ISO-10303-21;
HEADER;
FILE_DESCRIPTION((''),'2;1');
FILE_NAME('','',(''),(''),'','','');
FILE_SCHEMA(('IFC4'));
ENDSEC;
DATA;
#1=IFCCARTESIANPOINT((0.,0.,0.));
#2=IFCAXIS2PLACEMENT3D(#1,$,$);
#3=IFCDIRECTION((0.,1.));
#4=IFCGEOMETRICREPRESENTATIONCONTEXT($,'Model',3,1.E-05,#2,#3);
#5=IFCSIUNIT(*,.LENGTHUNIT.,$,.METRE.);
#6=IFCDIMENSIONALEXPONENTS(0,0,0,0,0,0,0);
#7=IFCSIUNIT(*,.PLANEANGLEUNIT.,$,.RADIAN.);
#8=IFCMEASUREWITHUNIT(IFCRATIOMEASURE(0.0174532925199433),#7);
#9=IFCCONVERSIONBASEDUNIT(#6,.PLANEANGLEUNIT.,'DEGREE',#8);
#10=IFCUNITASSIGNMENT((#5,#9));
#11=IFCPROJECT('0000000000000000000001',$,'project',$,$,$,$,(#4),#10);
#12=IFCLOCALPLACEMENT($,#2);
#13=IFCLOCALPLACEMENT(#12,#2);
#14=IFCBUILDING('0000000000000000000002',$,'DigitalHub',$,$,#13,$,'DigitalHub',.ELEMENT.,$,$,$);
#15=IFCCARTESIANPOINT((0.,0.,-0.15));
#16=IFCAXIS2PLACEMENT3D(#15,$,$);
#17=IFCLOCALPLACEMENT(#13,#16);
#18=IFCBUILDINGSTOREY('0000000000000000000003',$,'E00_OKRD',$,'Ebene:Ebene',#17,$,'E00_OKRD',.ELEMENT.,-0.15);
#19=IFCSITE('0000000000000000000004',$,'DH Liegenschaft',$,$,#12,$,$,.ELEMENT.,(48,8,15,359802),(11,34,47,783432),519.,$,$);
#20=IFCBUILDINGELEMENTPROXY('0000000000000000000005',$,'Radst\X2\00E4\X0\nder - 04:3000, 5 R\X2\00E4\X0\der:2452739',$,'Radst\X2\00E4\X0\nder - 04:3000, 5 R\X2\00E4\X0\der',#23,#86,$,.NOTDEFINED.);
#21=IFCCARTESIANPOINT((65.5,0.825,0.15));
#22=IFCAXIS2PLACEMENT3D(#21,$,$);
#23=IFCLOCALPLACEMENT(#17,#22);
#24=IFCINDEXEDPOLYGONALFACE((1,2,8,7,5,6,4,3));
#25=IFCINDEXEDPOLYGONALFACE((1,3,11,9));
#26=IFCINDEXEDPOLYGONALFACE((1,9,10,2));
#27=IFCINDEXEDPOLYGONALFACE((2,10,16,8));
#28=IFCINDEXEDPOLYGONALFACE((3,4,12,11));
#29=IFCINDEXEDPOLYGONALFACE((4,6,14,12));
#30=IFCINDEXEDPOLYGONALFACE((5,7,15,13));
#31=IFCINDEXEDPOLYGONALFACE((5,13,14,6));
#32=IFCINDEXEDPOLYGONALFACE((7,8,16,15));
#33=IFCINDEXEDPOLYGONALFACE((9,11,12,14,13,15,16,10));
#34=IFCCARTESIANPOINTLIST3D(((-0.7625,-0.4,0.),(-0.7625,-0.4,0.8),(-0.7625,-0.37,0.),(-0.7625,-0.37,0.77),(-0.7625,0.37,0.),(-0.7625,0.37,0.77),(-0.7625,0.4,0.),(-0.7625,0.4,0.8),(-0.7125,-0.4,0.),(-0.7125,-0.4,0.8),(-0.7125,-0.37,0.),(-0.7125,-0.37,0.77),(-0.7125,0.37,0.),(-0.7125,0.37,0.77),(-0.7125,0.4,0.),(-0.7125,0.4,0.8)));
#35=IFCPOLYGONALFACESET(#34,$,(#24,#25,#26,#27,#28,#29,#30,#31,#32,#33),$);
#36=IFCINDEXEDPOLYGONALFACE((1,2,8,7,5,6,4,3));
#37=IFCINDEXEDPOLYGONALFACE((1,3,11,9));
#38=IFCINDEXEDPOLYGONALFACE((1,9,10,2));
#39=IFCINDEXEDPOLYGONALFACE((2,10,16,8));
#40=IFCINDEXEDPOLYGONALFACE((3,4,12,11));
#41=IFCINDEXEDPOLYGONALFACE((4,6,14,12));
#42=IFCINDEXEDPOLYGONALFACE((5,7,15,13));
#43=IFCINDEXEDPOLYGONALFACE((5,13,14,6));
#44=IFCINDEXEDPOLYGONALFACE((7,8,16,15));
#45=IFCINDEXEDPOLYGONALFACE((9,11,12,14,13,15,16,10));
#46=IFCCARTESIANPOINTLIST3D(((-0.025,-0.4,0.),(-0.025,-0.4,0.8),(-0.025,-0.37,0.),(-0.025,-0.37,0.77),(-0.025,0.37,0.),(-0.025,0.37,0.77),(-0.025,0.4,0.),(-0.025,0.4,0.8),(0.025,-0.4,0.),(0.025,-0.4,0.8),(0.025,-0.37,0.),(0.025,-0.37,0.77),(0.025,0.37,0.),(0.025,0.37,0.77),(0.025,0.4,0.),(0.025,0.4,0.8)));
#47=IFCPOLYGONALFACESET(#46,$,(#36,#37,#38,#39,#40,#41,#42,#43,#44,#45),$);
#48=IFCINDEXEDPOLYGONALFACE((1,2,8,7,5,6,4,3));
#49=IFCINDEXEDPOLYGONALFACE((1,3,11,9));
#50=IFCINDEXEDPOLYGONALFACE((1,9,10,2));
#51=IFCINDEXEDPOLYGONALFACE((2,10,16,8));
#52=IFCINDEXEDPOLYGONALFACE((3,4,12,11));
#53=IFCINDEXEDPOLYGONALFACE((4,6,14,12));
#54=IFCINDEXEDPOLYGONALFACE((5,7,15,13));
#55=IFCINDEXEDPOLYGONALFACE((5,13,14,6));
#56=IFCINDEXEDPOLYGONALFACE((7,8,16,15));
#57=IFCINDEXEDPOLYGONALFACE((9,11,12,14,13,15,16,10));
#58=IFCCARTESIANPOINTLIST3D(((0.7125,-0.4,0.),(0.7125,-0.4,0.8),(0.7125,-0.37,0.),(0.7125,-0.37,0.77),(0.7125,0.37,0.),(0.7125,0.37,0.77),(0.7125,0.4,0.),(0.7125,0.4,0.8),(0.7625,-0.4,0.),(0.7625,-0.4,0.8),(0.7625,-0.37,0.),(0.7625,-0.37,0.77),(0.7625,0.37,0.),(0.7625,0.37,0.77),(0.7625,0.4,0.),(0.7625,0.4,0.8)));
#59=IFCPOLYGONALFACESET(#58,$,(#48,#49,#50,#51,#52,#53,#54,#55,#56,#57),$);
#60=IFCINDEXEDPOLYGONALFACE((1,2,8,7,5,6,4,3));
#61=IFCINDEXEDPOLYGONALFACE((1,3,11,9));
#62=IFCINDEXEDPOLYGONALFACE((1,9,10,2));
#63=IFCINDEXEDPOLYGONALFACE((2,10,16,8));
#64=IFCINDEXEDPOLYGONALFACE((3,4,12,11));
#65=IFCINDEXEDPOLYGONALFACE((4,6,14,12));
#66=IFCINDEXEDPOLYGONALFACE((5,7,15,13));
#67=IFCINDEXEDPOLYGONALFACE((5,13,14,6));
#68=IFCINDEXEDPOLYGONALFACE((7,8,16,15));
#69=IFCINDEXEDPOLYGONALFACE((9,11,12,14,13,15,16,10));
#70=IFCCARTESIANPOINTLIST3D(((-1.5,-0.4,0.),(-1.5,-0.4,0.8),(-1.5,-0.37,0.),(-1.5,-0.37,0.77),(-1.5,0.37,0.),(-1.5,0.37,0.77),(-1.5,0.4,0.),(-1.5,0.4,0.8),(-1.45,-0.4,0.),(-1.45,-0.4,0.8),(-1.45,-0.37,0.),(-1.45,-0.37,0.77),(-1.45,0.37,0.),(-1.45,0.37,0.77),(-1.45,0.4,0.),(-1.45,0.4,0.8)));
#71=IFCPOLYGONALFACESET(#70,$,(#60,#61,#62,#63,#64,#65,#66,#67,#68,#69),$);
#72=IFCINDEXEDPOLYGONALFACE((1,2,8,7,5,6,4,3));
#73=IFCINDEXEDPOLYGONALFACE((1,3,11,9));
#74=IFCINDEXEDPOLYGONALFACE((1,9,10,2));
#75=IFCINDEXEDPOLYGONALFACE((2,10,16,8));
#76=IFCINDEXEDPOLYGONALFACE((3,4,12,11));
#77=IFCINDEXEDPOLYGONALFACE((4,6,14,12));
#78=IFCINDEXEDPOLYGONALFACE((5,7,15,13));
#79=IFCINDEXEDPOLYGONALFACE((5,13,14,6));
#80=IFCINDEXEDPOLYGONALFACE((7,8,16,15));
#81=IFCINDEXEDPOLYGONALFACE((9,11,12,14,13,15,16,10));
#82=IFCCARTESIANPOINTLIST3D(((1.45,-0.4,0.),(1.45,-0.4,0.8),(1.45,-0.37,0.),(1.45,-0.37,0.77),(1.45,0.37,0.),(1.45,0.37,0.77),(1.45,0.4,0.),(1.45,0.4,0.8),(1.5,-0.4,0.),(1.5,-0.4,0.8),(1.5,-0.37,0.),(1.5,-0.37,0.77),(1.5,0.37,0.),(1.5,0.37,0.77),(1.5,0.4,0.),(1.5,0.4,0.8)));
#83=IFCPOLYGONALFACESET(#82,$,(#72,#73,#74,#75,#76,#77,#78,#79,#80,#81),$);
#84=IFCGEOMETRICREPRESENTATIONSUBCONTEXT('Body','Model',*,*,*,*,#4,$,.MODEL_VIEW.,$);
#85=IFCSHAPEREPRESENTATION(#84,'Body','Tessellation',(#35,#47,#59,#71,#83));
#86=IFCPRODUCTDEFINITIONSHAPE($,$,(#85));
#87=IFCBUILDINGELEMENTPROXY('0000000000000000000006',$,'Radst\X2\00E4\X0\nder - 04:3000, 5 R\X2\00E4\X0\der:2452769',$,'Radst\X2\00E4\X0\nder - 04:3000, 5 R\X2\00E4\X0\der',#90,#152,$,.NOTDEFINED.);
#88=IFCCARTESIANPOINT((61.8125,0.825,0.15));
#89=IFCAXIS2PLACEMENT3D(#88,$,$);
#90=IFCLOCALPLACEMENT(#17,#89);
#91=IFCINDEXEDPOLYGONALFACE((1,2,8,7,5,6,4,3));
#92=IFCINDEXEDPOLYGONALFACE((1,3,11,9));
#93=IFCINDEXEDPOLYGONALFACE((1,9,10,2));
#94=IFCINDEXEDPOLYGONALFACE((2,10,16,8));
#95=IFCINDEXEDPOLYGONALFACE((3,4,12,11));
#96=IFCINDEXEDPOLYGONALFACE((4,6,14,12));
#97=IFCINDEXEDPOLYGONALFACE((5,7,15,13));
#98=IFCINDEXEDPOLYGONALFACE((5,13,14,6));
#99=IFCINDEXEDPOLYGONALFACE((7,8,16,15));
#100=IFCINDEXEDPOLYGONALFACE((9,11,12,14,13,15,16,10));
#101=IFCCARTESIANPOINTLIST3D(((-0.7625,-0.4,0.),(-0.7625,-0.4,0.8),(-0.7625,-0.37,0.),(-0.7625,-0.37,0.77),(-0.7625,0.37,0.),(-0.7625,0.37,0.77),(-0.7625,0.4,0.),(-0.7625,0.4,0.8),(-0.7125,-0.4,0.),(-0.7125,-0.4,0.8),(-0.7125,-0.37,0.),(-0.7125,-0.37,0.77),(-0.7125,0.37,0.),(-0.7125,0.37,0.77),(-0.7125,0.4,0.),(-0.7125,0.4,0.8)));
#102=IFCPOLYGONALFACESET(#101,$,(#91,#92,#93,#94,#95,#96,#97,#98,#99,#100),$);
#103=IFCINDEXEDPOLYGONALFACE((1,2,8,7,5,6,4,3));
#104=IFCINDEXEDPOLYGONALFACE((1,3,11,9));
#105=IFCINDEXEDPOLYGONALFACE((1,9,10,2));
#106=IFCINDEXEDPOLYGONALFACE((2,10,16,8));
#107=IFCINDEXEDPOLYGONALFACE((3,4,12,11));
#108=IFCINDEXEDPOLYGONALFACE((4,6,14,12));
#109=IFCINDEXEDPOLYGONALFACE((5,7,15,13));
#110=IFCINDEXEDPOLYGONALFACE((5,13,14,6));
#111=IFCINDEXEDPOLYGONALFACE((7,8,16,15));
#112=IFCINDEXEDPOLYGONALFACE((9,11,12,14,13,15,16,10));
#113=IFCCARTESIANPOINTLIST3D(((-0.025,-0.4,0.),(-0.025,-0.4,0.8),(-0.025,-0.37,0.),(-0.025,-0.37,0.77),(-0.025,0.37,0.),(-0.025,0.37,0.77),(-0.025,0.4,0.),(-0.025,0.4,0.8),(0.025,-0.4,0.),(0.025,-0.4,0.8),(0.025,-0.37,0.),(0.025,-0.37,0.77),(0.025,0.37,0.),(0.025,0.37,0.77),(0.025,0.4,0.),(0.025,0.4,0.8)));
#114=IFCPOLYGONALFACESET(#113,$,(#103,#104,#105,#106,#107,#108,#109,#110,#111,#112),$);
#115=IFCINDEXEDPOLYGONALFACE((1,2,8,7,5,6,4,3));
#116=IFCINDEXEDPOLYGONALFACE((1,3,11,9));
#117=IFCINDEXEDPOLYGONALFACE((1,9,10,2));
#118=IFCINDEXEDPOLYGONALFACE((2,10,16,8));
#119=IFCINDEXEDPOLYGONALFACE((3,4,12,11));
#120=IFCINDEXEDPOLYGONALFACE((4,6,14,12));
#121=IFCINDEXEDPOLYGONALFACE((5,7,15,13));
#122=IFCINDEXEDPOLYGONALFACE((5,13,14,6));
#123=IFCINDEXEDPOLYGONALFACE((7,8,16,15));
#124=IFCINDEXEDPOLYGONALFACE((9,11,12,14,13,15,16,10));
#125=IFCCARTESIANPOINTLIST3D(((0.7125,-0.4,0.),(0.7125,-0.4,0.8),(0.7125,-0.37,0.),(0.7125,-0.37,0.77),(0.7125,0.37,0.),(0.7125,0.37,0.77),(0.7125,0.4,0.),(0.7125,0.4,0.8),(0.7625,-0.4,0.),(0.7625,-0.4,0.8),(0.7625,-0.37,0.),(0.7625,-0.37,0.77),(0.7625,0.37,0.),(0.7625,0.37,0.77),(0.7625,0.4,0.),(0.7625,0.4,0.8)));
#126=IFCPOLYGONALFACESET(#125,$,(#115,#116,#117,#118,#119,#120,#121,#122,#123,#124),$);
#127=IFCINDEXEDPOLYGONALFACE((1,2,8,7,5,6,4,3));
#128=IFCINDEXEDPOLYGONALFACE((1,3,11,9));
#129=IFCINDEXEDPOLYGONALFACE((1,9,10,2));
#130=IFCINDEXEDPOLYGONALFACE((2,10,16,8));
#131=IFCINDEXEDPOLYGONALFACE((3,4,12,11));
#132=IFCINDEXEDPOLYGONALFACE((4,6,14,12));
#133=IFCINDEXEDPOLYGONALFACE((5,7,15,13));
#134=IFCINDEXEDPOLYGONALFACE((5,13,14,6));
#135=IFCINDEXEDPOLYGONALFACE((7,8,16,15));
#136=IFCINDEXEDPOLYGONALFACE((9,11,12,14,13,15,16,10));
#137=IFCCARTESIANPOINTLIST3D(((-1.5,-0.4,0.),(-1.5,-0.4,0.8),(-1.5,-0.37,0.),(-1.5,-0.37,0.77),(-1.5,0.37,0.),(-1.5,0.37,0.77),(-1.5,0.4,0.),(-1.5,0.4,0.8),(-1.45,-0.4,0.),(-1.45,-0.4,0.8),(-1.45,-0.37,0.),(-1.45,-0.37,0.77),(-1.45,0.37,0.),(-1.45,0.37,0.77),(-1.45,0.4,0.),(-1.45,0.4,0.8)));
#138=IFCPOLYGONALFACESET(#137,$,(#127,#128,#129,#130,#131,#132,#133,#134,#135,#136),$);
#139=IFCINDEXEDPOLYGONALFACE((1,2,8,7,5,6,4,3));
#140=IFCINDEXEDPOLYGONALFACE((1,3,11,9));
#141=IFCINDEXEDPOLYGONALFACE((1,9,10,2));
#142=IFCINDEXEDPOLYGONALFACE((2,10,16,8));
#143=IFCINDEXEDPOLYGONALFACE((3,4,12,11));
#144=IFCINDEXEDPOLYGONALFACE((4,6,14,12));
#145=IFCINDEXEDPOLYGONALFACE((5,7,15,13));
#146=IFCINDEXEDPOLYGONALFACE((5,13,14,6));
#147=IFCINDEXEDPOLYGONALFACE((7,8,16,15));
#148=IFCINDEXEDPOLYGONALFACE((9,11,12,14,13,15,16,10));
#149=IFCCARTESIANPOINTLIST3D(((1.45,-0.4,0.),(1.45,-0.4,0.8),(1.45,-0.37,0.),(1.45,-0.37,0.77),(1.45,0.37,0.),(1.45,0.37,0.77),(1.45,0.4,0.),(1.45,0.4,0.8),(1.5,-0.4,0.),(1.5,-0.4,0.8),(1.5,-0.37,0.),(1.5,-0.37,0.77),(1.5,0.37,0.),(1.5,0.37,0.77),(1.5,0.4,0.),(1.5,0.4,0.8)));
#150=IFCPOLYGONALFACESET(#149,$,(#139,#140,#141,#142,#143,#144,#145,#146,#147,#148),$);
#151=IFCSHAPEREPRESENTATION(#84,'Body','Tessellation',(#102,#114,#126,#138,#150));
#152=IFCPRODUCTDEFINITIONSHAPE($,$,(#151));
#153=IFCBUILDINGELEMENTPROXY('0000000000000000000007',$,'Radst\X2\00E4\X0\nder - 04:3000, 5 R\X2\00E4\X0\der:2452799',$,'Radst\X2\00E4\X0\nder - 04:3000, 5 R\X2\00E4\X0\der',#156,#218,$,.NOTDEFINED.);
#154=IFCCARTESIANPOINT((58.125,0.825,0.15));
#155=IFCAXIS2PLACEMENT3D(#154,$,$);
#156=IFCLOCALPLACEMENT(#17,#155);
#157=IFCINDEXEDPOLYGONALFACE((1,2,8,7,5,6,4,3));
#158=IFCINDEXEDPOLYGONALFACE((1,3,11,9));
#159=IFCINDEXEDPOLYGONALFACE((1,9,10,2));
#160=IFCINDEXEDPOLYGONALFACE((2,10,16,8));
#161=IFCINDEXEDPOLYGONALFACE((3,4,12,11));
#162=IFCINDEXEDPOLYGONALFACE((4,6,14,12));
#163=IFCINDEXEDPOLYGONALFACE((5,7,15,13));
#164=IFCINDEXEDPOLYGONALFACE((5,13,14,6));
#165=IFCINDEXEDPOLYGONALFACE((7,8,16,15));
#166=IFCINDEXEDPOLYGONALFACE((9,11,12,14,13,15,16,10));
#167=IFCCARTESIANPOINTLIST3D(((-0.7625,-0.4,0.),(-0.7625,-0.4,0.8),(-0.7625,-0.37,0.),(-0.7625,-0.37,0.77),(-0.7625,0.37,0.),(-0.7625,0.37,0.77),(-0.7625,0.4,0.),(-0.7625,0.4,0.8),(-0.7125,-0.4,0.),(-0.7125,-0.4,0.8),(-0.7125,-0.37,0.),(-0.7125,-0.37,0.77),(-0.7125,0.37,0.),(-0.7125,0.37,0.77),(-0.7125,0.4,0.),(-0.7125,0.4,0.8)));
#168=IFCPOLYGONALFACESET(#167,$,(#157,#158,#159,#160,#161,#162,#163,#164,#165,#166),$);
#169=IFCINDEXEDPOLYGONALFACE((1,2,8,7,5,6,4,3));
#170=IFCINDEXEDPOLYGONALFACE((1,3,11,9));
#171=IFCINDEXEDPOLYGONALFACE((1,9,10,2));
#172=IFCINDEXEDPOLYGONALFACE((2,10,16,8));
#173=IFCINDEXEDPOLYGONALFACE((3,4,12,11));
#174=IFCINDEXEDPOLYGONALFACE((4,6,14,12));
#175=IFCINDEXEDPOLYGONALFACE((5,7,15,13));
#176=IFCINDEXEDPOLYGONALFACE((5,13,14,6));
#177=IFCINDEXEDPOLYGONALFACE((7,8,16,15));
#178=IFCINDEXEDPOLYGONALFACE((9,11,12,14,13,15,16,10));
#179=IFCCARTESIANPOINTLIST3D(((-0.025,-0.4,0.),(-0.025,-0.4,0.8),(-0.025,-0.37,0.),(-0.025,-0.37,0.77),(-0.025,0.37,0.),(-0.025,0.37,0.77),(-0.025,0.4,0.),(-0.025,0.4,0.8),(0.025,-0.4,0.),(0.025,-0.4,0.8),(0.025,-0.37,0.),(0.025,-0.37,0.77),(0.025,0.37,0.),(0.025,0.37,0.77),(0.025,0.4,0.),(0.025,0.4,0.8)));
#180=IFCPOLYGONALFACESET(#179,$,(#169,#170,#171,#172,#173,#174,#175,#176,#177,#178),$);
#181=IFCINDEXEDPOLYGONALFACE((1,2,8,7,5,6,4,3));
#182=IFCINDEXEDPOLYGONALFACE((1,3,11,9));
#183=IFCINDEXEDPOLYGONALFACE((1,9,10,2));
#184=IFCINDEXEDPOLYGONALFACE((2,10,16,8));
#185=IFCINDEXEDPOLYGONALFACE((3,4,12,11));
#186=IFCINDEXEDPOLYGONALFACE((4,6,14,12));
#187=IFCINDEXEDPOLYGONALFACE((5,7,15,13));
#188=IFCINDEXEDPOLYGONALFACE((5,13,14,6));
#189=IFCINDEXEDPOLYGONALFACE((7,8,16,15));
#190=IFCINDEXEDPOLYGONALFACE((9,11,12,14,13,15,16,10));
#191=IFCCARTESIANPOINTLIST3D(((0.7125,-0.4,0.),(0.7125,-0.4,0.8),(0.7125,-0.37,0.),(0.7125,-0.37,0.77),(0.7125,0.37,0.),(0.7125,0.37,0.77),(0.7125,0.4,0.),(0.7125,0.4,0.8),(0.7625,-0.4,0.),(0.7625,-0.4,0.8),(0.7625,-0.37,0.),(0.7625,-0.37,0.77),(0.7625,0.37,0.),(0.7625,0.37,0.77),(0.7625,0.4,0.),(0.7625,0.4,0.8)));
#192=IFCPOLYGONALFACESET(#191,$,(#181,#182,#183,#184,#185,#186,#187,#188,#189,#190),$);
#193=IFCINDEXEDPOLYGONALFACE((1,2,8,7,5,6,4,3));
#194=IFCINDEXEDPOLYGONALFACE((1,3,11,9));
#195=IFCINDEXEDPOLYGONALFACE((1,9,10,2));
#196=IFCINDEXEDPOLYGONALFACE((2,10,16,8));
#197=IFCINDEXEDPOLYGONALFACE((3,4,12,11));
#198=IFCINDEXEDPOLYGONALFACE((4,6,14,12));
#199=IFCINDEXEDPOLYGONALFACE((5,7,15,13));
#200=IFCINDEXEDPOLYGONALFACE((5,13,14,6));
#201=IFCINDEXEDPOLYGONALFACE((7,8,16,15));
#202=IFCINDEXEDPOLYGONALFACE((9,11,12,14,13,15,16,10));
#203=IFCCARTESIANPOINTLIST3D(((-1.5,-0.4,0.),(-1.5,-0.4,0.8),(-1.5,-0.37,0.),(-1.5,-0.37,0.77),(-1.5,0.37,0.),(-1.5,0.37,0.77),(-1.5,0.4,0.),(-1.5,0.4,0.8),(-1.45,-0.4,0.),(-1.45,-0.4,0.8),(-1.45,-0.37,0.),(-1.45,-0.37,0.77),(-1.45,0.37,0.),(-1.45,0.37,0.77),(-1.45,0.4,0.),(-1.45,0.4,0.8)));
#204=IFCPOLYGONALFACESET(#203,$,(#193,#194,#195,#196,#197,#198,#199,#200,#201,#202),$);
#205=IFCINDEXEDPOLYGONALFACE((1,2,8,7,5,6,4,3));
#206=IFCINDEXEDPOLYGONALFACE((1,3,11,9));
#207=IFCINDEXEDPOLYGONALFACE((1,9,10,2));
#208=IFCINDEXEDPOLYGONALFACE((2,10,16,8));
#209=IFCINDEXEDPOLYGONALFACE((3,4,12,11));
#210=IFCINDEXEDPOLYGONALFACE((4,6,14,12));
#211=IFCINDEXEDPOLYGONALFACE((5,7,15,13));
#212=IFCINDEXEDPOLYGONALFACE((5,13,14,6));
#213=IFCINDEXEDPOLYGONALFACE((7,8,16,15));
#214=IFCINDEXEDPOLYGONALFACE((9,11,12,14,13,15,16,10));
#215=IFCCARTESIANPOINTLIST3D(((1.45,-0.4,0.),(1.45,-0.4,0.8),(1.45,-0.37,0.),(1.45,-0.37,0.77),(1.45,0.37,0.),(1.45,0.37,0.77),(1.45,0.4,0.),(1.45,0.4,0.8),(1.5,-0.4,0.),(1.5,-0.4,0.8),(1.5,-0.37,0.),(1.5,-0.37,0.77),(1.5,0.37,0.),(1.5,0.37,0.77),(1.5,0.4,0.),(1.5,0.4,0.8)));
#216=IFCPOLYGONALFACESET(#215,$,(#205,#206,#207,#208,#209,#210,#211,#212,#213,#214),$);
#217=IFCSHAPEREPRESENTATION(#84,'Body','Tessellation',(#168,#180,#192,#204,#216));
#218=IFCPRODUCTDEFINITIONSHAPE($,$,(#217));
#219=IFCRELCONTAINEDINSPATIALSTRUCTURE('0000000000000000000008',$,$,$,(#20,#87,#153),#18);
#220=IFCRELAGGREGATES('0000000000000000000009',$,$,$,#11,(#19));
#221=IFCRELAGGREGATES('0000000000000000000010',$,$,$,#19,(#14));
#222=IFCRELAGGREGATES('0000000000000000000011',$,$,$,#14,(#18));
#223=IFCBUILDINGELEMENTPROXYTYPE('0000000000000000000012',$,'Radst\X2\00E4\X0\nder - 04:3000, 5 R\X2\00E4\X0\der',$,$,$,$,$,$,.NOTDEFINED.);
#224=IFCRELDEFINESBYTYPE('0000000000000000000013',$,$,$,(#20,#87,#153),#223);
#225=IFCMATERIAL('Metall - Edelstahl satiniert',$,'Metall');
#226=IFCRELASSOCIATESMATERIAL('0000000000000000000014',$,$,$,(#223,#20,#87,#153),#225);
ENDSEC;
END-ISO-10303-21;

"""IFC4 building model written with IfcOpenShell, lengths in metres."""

from ifc_helpers import new_model, entity, si_unit, converted_unit, direction, frame, origin, place, context, subcontext, project, spatial, indexed_curve, outline, extrude, source, transform, mapped, material, type_object, type_shapes, element, save


model = new_model("IFC4")

# Units and contexts
model_context = context("Model", 3, precision=1e-05, world=origin(), true_north=direction((0.0, 1.0)))
body_context = subcontext(model_context, "Body", "Model", "MODEL_VIEW")
ifc_project = project(units=[si_unit("LENGTHUNIT", "METRE"), converted_unit("PLANEANGLEUNIT", "DEGREE", entity("IfcRatioMeasure", 0.0174532925199433), si_unit("PLANEANGLEUNIT", "RADIAN"), dimensions=[0, 0, 0, 0, 0, 0, 0])], contexts=[model_context])

# Site, building, storey
site_placement = place(None, frame((0.0, 0.0, 0.0)))
site = spatial("IfcSite", under=ifc_project, at=site_placement, Name="DH Liegenschaft", CompositionType="ELEMENT", RefLatitude=(48, 8, 15, 359802), RefLongitude=(11, 34, 47, 783432), RefElevation=519.0)
building_placement = place(site_placement, origin())
building = spatial("IfcBuilding", under=site, at=building_placement, Name="DigitalHub", LongName="DigitalHub", CompositionType="ELEMENT")
storey_placement = place(building_placement, frame((0.0, 0.0, -0.15)))
storey = spatial("IfcBuildingStorey", under=building, at=storey_placement, Name="E00_OKRD", ObjectType="Ebene:Ebene", LongName="E00_OKRD", CompositionType="ELEMENT", Elevation=-0.15)

# Building element proxies
ifc_material_1 = material(Name="Metall - Edelstahl satiniert", Category="Metall")
building_element_proxy_type_1 = type_object("IfcBuildingElementProxyType", Name="Radständer - 04:3000, 5 Räder", PredefinedType="NOTDEFINED", material=ifc_material_1)
shared_shape_1 = source(origin(), body_context, "Body", "SweptSolid", [
    extrude(outline(indexed_curve([(-0.4075, -0.4), (0.3925, -0.4), (0.3925, -0.37), (-0.3775, -0.37), (-0.3775, 0.37), (0.3925, 0.37), (0.3925, 0.4), (-0.4075, 0.4), (-0.4075, -0.4)], self_intersect=False)), frame((-0.7625, 0.0, 0.3925), z_axis=(1.0, 0.0, 0.0), x_axis=(0.0, 0.0, -1.0)), (0.0, 0.0, 1.0), 0.05),
    extrude(outline(indexed_curve([(-0.4075, -0.4), (0.3925, -0.4), (0.3925, -0.37), (-0.3775, -0.37), (-0.3775, 0.37), (0.3925, 0.37), (0.3925, 0.4), (-0.4075, 0.4), (-0.4075, -0.4)], self_intersect=False)), frame((-0.025, 0.0, 0.3925), z_axis=(1.0, 0.0, 0.0), x_axis=(0.0, 0.0, -1.0)), (0.0, 0.0, 1.0), 0.05),
    extrude(outline(indexed_curve([(-0.4075, -0.4), (0.3925, -0.4), (0.3925, -0.37), (-0.3775, -0.37), (-0.3775, 0.37), (0.3925, 0.37), (0.3925, 0.4), (-0.4075, 0.4), (-0.4075, -0.4)], self_intersect=False)), frame((0.7125, 0.0, 0.3925), z_axis=(1.0, 0.0, 0.0), x_axis=(0.0, 0.0, -1.0)), (0.0, 0.0, 1.0), 0.05),
    extrude(outline(indexed_curve([(-0.4075, -0.4), (0.3925, -0.4), (0.3925, -0.37), (-0.3775, -0.37), (-0.3775, 0.37), (0.3925, 0.37), (0.3925, 0.4), (-0.4075, 0.4), (-0.4075, -0.4)], self_intersect=False)), frame((-1.5, 0.0, 0.3925), z_axis=(1.0, 0.0, 0.0), x_axis=(0.0, 0.0, -1.0)), (0.0, 0.0, 1.0), 0.05),
    extrude(outline(indexed_curve([(-0.4075, -0.4), (0.3925, -0.4), (0.3925, -0.37), (-0.3775, -0.37), (-0.3775, 0.37), (0.3925, 0.37), (0.3925, 0.4), (-0.4075, 0.4), (-0.4075, -0.4)], self_intersect=False)), frame((1.45, 0.0, 0.3925), z_axis=(1.0, 0.0, 0.0), x_axis=(0.0, 0.0, -1.0)), (0.0, 0.0, 1.0), 0.05),
])
type_shapes(building_element_proxy_type_1, [shared_shape_1])
for number, where, name in (
    (1, (65.5, 0.825, 0.15), "Radständer - 04:3000, 5 Räder:2452739"),
    (2, (61.8125, 0.825, 0.15), "Radständer - 04:3000, 5 Räder:2452769"),
    (3, (58.125, 0.825, 0.15), "Radständer - 04:3000, 5 Räder:2452799"),
):
    element("IfcBuildingElementProxy", number, at=place(storey_placement, frame(where)), inside=storey, type_object=building_element_proxy_type_1, material=ifc_material_1, Name=name, ObjectType="Radständer - 04:3000, 5 Räder", PredefinedType="NOTDEFINED", context=body_context, shape_type="MappedRepresentation", body=[
        mapped(shared_shape_1, transform((0.0, 0.0, 0.0), scale=1.0)),
    ])

save(model, "model.ifc")
